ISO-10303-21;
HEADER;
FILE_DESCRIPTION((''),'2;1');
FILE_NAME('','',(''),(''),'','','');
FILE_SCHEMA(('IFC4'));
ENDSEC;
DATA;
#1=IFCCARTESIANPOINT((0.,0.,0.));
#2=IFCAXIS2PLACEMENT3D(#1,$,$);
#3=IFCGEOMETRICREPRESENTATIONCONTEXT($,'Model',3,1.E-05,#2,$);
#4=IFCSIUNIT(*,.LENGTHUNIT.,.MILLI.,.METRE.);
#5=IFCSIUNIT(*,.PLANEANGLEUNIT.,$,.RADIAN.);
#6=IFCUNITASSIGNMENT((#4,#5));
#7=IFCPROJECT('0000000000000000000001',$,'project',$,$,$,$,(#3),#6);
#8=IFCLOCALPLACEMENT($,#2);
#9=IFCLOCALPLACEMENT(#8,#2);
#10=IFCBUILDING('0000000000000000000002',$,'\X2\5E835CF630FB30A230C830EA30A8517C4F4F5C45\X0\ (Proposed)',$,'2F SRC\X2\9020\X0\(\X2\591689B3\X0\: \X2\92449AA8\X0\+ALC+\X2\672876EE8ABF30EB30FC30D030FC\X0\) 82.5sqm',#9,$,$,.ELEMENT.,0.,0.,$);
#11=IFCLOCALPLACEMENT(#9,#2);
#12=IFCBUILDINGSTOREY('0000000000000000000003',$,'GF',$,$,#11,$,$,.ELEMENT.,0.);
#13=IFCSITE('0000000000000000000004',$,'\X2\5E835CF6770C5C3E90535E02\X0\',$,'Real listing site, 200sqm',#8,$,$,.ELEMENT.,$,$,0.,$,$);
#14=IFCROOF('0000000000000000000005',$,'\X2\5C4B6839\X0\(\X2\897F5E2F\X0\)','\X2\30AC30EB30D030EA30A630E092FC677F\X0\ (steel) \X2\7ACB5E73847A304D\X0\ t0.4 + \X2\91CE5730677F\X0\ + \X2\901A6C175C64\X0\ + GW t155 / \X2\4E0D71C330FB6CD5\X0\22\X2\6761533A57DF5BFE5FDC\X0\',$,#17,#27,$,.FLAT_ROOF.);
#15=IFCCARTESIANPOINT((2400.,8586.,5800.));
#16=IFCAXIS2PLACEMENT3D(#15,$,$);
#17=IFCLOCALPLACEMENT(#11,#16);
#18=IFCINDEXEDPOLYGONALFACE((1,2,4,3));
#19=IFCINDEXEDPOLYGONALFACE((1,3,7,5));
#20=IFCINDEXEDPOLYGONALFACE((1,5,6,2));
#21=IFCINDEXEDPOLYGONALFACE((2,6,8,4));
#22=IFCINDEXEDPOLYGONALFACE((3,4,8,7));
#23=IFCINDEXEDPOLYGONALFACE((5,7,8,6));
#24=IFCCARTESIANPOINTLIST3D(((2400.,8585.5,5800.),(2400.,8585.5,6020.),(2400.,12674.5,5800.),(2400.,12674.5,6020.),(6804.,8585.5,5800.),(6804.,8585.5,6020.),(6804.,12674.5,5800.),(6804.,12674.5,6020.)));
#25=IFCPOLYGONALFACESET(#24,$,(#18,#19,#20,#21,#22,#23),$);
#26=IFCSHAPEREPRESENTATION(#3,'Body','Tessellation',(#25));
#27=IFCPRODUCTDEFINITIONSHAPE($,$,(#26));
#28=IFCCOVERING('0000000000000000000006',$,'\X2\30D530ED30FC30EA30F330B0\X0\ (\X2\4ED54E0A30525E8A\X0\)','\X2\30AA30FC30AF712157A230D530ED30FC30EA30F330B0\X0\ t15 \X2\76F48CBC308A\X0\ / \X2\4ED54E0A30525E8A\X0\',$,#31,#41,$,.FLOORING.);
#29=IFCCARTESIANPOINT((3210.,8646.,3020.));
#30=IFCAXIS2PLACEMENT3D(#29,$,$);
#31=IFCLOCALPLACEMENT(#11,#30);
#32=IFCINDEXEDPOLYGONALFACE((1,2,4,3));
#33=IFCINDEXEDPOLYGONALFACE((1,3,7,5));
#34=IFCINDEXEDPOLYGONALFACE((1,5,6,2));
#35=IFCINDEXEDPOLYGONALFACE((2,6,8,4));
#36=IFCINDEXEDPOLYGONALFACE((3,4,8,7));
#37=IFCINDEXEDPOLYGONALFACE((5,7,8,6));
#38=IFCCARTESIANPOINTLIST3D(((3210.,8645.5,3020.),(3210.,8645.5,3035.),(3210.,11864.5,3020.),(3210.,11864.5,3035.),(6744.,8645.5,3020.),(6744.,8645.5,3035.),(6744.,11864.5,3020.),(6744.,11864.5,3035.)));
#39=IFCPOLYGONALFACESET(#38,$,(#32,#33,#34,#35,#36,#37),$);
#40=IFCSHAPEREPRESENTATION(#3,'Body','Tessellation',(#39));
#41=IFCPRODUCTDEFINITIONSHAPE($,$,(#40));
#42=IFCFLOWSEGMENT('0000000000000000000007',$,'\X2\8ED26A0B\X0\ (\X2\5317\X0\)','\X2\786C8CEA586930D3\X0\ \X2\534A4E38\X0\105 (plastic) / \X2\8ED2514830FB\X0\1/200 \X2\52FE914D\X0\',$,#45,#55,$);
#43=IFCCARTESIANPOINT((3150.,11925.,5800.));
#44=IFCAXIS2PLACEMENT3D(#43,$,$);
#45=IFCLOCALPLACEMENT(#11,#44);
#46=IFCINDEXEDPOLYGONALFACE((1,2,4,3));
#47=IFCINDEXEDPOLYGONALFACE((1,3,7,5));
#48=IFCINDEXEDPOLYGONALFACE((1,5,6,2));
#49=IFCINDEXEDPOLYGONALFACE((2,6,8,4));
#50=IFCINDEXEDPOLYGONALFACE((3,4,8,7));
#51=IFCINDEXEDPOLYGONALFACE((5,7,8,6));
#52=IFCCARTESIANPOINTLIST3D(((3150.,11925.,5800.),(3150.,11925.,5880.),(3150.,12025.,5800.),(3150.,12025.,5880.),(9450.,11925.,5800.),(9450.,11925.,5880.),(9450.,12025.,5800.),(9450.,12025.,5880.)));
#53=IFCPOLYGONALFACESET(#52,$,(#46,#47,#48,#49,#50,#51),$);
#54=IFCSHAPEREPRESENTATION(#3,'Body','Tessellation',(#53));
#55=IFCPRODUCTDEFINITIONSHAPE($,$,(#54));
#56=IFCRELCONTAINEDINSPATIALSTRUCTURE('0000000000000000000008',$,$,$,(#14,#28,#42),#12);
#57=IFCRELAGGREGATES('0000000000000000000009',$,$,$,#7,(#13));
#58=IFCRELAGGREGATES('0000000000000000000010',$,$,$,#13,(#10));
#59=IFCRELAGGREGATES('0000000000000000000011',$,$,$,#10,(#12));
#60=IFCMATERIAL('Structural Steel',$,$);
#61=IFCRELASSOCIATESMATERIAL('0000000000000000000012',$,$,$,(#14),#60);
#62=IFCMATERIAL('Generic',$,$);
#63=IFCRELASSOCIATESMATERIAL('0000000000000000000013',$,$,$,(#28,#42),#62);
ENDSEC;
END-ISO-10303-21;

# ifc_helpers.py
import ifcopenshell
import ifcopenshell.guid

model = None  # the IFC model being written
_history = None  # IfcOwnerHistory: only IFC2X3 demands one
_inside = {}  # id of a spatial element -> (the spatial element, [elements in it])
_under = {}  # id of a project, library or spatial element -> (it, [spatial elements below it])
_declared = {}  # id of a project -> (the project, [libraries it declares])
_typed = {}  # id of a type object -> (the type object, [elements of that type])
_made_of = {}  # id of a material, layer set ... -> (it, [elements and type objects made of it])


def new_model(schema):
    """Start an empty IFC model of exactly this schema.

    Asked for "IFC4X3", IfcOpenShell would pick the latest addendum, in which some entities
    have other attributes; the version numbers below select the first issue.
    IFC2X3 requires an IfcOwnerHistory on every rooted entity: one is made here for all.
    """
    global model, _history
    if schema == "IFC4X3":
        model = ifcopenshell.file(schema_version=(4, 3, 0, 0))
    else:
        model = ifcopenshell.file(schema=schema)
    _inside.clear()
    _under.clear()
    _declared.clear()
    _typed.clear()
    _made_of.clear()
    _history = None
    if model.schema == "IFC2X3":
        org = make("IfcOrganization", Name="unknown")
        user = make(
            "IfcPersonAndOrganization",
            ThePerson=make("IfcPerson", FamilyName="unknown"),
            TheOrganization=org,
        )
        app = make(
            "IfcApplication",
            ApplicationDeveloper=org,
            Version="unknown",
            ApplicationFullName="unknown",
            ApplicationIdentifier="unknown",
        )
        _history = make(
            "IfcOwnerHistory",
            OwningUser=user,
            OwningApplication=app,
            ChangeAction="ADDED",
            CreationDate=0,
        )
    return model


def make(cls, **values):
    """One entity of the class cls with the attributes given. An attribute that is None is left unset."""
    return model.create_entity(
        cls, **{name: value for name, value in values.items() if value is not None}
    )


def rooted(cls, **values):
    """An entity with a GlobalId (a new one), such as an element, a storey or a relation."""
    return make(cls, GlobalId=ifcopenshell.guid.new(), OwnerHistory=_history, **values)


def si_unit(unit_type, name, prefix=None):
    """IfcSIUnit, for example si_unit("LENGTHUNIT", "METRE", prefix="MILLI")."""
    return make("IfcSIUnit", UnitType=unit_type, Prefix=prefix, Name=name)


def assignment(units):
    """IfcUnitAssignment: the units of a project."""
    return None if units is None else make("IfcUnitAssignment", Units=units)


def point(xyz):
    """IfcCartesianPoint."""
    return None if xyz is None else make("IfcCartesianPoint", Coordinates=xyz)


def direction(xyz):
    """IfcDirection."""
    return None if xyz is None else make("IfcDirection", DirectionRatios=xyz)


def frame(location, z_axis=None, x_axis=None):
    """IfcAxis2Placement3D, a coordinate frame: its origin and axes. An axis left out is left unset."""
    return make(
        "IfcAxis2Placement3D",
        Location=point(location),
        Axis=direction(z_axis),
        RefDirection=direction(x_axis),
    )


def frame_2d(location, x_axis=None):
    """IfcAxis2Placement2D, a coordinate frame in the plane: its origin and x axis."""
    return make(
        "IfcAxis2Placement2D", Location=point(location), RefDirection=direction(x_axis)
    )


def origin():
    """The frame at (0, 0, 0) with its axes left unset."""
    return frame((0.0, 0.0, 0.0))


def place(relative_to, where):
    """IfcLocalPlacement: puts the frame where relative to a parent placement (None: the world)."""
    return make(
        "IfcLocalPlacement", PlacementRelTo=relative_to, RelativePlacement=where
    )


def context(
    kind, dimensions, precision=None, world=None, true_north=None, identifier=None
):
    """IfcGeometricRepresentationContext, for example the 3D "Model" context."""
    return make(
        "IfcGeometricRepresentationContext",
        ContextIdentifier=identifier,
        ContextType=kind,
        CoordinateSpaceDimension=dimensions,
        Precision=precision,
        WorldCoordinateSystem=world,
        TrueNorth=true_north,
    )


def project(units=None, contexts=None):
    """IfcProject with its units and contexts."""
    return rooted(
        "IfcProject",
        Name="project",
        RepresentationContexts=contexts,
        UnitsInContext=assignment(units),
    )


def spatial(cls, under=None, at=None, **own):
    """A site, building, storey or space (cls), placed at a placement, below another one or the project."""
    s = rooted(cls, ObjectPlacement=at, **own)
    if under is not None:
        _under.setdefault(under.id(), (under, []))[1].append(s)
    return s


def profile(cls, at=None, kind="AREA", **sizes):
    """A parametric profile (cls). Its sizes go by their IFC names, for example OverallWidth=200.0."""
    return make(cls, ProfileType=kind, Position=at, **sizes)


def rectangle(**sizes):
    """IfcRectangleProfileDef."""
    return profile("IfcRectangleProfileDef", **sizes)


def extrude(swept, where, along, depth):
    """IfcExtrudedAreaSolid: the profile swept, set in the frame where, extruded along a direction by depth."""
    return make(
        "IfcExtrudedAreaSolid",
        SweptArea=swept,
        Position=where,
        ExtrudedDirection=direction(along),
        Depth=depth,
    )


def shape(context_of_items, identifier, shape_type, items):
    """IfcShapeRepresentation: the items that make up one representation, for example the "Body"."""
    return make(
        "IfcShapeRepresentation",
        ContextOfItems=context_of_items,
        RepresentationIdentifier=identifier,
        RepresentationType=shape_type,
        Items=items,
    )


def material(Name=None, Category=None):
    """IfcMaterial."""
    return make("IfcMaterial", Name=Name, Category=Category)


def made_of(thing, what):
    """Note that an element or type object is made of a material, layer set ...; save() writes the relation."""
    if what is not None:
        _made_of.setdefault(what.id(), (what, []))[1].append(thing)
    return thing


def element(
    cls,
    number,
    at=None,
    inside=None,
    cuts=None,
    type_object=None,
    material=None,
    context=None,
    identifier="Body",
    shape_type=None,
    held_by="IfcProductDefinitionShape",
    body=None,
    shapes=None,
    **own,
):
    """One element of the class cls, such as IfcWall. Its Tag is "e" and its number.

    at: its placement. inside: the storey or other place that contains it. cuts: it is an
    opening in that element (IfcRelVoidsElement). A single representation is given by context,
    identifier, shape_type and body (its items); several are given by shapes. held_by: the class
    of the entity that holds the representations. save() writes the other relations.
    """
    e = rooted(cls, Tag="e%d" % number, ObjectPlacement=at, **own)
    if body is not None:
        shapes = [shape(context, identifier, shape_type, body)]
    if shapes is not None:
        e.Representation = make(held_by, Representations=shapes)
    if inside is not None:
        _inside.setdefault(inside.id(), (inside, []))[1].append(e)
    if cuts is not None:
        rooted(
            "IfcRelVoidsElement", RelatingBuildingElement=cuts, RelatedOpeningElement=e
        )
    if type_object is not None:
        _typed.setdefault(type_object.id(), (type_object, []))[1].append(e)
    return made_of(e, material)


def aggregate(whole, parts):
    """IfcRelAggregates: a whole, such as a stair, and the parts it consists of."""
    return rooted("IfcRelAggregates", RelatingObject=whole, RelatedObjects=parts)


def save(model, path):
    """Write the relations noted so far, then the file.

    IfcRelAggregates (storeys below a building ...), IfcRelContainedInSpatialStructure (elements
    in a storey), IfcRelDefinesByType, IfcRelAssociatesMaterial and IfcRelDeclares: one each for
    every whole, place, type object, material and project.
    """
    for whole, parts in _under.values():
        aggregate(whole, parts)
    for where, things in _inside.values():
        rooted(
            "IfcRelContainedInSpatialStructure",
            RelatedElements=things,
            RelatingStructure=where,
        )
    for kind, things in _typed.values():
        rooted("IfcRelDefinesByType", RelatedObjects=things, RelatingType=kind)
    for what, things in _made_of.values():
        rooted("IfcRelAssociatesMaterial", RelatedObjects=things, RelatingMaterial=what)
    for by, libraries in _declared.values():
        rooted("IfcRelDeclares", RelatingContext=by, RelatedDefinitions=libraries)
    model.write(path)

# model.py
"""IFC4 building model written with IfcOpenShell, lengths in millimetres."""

from ifc_helpers import new_model, si_unit, frame, frame_2d, origin, place, context, project, spatial, rectangle, extrude, material, element, save


model = new_model("IFC4")

# Units and contexts
model_context = context("Model", 3, precision=1e-05, world=origin())
ifc_project = project(units=[si_unit("LENGTHUNIT", "METRE", prefix="MILLI"), si_unit("PLANEANGLEUNIT", "RADIAN")], contexts=[model_context])

# Site, building, storey
site_placement = place(None, origin())
site = spatial("IfcSite", under=ifc_project, at=site_placement, Name="広島県尾道市", ObjectType="Real listing site, 200sqm", CompositionType="ELEMENT", RefElevation=0.0)
building_placement = place(site_placement, origin())
building = spatial("IfcBuilding", under=site, at=building_placement, Name="広島・アトリエ兼住居 (Proposed)", ObjectType="2F SRC造(外観: 鉄骨+ALC+木目調ルーバー) 82.5sqm", CompositionType="ELEMENT", ElevationOfRefHeight=0.0, ElevationOfTerrain=0.0)
storey_placement = place(building_placement, origin())
storey = spatial("IfcBuildingStorey", under=building, at=storey_placement, Name="GF", CompositionType="ELEMENT", Elevation=0.0)

# Roof
ifc_material_1 = material(Name="Structural Steel")
for number, where, name in (
    (1, (2400.0, 8586.0, 5800.0), "屋根(西帯)"),
):
    element("IfcRoof", number, at=place(storey_placement, frame(where)), inside=storey, material=ifc_material_1, Name=name, Description="ガルバリウム鋼板 (steel) 立平葺き t0.4 + 野地板 + 通気層 + GW t155 / 不燃・法22条区域対応", PredefinedType="FLAT_ROOF", context=model_context, shape_type="SweptSolid", body=[
        extrude(rectangle(XDim=4404.0, YDim=4089.0, at=frame_2d((2202.0, 2044.0))), frame((2400.0, 8586.0, 5800.0)), (0.0, 0.0, 1.0), 220.0),
    ])

# Covering
ifc_material_2 = material(Name="Generic")
covering_placement = place(storey_placement, frame((3210.0, 8646.0, 3020.0)))
element("IfcCovering", 2, at=covering_placement, inside=storey, material=ifc_material_2, Name="フローリング (仕上げ床)", Description="オーク無垢フローリング t15 直貼り / 仕上げ床", PredefinedType="FLOORING", context=model_context, shape_type="SweptSolid", body=[
    extrude(rectangle(XDim=3534.0, YDim=3219.0, at=frame_2d((1767.0, 1609.0))), frame((3210.0, 8646.0, 3020.0)), (0.0, 0.0, 1.0), 15.0),
])

# Flow segment
flow_segment_placement = place(storey_placement, frame((3150.0, 11925.0, 5800.0)))
element("IfcFlowSegment", 3, at=flow_segment_placement, inside=storey, material=ifc_material_2, Name="軒樋 (北)", Description="硬質塩ビ 半丸105 (plastic) / 軒先・1/200 勾配", context=model_context, shape_type="SweptSolid", body=[
    extrude(rectangle(XDim=6300.0, YDim=100.0, at=frame_2d((3150.0, 50.0))), frame((3150.0, 11925.0, 5800.0)), (0.0, 0.0, 1.0), 80.0),
])

save(model, "model.ifc")
